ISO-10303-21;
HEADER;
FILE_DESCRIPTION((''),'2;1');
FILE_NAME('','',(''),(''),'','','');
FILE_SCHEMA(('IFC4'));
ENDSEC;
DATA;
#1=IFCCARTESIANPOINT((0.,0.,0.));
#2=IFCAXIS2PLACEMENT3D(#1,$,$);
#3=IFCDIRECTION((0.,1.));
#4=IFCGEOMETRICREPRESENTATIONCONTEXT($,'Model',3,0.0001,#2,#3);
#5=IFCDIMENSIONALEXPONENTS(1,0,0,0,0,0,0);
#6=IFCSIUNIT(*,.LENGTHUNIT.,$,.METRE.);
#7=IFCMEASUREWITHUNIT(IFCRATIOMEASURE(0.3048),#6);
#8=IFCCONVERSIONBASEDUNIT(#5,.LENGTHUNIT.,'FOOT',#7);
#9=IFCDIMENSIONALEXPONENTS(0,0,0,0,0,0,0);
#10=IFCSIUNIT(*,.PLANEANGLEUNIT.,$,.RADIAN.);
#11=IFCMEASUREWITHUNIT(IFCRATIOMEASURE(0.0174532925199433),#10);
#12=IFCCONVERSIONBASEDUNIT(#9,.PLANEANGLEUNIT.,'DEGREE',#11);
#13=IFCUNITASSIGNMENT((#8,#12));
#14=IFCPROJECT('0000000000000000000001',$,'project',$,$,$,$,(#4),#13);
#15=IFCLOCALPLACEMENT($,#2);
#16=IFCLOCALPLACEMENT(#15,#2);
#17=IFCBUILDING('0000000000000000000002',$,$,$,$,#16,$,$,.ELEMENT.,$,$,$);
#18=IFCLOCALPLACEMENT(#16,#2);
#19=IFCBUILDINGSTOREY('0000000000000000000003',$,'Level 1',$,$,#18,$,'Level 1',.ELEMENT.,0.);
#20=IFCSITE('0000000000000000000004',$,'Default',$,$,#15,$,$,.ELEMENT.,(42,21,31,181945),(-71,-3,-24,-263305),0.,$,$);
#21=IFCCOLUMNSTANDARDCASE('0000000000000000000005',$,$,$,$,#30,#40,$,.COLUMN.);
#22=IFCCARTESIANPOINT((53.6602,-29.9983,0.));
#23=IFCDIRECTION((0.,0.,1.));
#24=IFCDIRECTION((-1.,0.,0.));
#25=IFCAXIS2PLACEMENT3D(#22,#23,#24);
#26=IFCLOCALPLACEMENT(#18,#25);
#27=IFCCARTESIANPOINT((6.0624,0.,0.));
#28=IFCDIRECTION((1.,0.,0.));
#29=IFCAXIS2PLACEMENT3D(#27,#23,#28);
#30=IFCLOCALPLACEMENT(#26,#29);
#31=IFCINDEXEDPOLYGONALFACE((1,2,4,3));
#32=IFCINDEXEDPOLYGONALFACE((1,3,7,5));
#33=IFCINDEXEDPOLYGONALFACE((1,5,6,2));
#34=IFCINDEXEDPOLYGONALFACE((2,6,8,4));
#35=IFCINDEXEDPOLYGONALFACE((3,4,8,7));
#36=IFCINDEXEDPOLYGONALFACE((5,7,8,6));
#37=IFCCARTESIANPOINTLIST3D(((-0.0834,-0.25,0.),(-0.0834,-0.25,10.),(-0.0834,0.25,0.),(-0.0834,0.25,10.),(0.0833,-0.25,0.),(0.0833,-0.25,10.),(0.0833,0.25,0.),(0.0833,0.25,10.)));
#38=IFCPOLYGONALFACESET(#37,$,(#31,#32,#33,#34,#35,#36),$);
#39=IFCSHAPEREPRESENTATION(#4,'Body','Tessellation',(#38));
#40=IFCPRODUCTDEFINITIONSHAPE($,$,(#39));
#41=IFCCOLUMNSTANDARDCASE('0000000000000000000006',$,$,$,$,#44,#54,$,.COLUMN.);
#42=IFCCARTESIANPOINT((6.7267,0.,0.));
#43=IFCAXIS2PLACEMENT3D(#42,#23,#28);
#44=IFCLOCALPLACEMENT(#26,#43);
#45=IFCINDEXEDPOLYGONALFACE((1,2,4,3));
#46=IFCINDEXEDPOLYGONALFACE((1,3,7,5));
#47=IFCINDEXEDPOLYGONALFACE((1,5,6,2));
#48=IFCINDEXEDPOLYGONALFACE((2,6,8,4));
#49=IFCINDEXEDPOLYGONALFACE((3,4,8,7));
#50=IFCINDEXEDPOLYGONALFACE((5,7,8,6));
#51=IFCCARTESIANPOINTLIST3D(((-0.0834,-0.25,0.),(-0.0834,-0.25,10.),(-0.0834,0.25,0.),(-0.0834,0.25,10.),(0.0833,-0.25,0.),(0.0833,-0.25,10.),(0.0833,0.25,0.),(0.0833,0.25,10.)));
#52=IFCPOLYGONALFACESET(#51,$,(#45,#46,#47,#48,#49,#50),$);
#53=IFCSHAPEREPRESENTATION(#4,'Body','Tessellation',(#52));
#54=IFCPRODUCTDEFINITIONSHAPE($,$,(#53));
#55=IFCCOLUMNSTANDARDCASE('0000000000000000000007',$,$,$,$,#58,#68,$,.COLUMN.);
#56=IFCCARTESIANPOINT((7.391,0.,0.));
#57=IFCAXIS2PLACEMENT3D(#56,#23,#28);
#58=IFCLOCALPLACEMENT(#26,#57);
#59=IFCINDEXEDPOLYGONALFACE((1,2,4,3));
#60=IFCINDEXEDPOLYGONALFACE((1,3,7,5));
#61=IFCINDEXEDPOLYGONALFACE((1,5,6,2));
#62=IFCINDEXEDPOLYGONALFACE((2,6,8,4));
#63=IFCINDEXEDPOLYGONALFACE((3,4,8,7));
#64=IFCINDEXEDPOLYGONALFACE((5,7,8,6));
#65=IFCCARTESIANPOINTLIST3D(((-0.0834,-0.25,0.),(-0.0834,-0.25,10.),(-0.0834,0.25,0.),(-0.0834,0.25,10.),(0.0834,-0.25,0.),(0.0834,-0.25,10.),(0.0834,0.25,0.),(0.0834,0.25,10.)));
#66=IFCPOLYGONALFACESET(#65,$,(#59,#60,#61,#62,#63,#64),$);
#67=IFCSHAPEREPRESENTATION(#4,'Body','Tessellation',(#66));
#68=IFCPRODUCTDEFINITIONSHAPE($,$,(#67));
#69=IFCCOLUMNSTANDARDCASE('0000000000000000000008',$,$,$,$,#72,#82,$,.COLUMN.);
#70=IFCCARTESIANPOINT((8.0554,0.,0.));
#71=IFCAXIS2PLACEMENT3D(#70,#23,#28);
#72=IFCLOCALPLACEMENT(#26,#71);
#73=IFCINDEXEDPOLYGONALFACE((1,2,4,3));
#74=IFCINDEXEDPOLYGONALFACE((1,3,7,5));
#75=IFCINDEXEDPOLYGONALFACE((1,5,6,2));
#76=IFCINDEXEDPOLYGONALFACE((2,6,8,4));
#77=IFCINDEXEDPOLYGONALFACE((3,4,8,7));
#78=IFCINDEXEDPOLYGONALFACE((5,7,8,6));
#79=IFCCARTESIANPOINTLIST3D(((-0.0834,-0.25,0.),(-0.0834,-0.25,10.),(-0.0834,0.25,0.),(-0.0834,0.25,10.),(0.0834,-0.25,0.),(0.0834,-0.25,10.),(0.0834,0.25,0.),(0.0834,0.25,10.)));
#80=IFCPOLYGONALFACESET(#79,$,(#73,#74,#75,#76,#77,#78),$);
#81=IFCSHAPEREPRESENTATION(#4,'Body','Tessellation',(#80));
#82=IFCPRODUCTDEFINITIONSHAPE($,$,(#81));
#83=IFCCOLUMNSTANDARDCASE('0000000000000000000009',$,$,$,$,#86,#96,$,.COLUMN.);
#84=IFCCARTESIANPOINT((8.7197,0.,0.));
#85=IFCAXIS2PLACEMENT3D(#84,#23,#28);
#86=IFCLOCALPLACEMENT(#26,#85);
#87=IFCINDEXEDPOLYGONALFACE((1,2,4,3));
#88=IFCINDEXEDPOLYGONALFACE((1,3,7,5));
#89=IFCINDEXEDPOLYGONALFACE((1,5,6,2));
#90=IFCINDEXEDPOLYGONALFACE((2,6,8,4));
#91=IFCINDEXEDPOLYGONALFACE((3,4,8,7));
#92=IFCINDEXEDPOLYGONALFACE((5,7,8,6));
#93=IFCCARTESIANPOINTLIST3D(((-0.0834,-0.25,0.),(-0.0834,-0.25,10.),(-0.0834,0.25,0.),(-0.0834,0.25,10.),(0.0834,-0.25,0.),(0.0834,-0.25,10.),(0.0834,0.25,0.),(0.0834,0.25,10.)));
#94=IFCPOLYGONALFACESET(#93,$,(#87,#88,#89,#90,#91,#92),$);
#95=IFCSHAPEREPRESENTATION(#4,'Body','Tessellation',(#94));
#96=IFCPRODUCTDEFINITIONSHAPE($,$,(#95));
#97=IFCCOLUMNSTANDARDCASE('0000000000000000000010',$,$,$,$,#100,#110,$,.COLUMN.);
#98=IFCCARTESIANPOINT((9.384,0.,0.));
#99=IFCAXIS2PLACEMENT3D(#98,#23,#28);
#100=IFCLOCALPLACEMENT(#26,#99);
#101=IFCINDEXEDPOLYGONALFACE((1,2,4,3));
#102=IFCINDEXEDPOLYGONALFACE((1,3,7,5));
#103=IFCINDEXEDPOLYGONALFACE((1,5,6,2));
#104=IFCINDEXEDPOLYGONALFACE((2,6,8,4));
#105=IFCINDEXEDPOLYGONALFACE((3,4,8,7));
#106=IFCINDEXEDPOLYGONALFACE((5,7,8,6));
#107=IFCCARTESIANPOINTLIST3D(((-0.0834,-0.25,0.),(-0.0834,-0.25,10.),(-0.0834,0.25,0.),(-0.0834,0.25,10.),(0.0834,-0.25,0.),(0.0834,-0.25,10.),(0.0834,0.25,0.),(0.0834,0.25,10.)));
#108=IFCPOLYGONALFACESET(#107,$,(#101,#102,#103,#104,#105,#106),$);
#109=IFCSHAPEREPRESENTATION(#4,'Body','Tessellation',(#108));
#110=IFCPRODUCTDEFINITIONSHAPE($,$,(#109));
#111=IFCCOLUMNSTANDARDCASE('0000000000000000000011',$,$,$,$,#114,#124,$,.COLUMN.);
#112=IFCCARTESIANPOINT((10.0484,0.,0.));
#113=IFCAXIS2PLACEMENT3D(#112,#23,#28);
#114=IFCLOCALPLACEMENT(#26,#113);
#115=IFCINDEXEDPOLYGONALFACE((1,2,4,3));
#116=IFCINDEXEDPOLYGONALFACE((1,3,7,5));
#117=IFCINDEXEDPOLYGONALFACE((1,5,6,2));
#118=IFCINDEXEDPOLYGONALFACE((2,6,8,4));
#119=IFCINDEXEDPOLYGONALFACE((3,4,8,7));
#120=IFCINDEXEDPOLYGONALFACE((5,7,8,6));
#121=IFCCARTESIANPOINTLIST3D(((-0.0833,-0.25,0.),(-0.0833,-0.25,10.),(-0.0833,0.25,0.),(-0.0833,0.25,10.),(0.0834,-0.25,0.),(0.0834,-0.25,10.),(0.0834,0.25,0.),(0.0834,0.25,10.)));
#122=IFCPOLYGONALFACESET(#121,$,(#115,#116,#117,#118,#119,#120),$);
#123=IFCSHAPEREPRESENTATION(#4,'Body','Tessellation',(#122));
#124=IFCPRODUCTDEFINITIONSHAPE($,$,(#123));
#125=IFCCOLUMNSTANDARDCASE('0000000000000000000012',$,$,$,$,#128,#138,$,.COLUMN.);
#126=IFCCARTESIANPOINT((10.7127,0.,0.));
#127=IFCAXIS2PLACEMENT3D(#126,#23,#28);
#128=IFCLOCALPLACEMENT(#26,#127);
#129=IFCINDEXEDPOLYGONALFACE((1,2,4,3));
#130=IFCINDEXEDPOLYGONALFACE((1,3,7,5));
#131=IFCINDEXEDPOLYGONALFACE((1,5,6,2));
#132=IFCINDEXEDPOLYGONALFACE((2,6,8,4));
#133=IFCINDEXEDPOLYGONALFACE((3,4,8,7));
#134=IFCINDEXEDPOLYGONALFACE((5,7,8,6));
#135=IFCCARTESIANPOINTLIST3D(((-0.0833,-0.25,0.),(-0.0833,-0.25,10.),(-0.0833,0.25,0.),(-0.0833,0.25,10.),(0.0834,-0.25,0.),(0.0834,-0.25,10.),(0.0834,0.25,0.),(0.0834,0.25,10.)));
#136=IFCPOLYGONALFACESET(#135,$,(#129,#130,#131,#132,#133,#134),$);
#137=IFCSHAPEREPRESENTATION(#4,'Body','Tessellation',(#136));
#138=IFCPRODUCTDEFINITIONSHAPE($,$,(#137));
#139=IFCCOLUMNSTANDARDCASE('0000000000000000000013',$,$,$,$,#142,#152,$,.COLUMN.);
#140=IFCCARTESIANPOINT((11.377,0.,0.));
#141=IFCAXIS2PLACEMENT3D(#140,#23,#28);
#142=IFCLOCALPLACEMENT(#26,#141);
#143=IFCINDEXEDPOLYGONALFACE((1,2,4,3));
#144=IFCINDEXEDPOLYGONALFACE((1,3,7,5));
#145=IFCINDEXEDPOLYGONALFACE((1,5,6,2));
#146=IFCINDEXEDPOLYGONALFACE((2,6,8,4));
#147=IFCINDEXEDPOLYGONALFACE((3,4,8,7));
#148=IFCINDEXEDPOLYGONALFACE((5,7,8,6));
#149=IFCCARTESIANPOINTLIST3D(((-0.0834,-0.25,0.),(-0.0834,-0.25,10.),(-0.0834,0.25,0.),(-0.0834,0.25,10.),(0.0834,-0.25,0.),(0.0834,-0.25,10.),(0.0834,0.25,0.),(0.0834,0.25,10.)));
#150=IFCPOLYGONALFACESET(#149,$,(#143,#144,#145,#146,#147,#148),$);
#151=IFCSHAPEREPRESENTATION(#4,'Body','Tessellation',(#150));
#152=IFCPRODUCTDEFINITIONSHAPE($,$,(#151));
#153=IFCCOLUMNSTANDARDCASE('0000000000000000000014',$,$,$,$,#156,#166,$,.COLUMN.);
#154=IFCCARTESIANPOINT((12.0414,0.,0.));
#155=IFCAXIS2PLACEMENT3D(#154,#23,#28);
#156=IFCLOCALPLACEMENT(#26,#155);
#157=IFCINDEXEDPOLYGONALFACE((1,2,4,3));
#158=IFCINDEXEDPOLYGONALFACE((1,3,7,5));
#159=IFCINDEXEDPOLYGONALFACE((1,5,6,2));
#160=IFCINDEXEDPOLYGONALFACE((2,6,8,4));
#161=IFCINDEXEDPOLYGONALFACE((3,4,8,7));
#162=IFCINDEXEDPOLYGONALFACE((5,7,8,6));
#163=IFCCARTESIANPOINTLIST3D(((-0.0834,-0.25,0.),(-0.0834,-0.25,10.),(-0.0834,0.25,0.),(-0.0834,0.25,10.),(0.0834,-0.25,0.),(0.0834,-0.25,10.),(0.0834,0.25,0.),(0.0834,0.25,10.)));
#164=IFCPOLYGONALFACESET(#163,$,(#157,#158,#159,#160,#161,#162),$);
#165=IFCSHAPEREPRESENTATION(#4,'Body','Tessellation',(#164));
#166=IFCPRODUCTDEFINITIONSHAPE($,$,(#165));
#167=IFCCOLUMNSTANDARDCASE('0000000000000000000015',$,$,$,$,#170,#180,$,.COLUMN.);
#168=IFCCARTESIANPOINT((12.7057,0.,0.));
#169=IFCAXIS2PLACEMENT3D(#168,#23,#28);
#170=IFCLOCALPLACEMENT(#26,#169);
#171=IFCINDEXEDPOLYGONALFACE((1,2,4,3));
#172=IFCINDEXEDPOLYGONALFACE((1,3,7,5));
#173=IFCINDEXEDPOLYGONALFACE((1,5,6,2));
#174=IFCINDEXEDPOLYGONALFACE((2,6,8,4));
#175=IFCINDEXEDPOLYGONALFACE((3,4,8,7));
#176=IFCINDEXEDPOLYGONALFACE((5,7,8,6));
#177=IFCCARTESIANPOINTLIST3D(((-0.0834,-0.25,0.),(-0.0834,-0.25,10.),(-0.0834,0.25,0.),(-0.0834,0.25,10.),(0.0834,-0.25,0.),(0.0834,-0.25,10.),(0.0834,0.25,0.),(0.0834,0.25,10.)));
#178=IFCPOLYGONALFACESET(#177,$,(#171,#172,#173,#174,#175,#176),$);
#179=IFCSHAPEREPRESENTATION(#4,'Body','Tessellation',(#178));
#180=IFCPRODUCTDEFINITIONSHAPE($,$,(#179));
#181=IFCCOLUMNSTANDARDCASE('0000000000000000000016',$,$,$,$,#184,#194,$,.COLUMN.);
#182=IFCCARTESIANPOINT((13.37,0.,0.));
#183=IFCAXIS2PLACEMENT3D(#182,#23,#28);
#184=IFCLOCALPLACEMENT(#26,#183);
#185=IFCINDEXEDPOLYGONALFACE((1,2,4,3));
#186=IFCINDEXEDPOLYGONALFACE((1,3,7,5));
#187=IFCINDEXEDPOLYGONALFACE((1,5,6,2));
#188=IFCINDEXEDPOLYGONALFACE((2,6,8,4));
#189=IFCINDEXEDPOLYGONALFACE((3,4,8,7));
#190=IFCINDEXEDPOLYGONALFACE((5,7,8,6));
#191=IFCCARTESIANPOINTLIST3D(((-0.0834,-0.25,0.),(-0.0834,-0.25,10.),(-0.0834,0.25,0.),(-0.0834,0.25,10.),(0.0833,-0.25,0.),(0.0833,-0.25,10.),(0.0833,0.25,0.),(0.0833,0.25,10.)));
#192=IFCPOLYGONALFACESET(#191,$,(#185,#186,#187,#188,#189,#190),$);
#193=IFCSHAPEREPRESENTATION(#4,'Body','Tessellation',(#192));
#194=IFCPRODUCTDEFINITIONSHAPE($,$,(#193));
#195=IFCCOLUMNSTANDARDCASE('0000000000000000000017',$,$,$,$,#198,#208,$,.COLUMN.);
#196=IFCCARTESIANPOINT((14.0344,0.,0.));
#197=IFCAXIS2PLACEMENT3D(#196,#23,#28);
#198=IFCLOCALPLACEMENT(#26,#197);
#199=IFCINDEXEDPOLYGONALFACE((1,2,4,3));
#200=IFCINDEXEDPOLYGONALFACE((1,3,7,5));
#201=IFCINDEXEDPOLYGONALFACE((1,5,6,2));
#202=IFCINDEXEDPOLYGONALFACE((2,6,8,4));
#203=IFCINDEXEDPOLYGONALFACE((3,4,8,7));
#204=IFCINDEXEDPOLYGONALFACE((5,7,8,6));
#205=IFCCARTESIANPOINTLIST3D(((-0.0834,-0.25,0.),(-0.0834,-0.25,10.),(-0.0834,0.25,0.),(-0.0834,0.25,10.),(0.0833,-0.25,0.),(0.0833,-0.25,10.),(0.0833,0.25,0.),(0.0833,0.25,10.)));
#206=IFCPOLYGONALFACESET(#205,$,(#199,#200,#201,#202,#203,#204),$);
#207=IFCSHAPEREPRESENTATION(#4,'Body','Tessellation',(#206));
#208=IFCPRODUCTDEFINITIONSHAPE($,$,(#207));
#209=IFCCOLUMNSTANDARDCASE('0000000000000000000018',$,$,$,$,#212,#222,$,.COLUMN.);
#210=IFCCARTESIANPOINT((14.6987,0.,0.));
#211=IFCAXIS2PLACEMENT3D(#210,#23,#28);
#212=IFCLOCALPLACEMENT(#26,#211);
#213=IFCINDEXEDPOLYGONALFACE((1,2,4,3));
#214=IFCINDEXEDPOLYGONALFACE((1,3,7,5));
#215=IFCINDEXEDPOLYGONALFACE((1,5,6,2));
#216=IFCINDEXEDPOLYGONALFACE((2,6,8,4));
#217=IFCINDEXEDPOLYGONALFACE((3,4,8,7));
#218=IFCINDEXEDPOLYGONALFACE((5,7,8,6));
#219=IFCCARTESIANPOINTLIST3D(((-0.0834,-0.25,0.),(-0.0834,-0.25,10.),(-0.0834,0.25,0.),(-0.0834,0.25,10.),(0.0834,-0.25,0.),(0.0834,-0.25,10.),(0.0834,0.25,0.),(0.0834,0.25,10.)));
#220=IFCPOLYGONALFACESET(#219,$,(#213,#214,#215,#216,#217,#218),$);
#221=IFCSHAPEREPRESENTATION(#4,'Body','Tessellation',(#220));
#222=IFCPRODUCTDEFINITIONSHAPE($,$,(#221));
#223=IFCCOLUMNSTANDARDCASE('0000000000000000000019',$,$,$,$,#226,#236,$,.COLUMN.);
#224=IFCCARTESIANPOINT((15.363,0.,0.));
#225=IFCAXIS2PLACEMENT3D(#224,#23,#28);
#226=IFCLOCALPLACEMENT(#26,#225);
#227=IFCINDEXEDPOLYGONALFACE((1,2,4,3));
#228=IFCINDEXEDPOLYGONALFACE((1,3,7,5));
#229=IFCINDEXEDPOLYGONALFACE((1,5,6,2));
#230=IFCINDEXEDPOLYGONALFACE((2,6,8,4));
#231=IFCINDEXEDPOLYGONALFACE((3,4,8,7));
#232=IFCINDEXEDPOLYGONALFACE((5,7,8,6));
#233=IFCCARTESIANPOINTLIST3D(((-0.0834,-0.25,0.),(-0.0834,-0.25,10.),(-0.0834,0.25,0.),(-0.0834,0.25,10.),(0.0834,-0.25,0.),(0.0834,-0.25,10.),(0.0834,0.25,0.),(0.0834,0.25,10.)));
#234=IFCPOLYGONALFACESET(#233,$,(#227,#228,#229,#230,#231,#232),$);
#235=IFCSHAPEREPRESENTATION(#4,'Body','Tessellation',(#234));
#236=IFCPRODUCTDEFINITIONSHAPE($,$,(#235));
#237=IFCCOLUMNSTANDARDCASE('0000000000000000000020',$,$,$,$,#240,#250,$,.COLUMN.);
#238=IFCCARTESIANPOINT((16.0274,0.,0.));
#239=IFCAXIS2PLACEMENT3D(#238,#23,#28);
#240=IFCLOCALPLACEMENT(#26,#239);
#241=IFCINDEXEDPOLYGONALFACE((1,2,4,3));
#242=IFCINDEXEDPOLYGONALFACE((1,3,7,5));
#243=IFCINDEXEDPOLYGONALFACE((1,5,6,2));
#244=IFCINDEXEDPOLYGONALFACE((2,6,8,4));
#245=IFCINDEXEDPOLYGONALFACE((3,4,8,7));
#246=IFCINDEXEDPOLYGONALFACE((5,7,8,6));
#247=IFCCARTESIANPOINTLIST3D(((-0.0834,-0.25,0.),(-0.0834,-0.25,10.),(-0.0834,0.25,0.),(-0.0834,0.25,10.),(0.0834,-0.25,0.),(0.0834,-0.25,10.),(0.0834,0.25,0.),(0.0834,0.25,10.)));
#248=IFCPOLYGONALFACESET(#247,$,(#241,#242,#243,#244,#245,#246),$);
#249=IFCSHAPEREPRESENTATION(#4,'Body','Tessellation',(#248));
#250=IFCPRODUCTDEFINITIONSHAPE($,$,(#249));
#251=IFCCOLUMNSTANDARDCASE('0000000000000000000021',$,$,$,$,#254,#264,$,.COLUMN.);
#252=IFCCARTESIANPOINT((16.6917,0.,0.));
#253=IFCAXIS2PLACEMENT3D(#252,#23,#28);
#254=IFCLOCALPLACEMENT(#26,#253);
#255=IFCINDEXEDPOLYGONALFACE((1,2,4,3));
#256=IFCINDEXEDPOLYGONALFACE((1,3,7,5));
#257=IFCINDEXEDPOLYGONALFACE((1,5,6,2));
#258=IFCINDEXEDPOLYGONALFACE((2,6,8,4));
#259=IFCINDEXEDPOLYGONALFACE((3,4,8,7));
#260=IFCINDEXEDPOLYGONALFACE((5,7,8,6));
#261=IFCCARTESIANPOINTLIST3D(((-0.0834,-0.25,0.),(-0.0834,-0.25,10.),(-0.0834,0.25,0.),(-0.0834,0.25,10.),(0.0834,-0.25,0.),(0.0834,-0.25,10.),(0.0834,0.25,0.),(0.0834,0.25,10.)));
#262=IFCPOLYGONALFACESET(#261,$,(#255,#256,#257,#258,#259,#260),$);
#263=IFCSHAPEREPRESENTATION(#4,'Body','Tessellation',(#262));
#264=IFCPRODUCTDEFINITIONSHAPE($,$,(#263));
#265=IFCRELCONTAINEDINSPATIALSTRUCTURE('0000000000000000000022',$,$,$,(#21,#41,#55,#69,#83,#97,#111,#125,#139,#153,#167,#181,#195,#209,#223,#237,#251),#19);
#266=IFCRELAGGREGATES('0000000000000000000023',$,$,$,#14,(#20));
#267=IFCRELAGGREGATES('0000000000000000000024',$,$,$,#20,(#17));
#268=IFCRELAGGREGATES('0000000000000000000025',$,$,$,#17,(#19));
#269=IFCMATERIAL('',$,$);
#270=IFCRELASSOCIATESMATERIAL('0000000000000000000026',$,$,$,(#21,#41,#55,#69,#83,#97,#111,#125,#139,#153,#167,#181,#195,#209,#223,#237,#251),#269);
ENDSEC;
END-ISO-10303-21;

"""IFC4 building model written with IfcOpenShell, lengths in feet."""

from ifc_helpers import new_model, entity, si_unit, converted_unit, direction, frame, origin, place, context, project, spatial, rectangle, extrude, material, element, save


model = new_model("IFC4")

# Units and contexts
model_context = context("Model", 3, precision=0.0001, world=origin(), true_north=direction((0.0, 1.0)))
ifc_project = project(units=[converted_unit("LENGTHUNIT", "FOOT", entity("IfcRatioMeasure", 0.3048), si_unit("LENGTHUNIT", "METRE"), dimensions=[1, 0, 0, 0, 0, 0, 0]), converted_unit("PLANEANGLEUNIT", "DEGREE", entity("IfcRatioMeasure", 0.0174532925199433), si_unit("PLANEANGLEUNIT", "RADIAN"), dimensions=[0, 0, 0, 0, 0, 0, 0])], contexts=[model_context])

# Site, building, storey
site_placement = place(None, origin())
site = spatial("IfcSite", under=ifc_project, at=site_placement, Name="Default", CompositionType="ELEMENT", RefLatitude=(42, 21, 31, 181945), RefLongitude=(-71, -3, -24, -263305), RefElevation=0.0)
building_placement = place(site_placement, origin())
building = spatial("IfcBuilding", under=site, at=building_placement, CompositionType="ELEMENT")
storey_placement = place(building_placement, origin())
storey = spatial("IfcBuildingStorey", under=building, at=storey_placement, Name="Level 1", LongName="Level 1", CompositionType="ELEMENT", Elevation=0.0)

# Columns
ifc_material = material(Name="")
placement_1 = place(storey_placement, frame((53.6602, -29.9983, 0.0), z_axis=(0.0, 0.0, 1.0), x_axis=(-1.0, 0.0, 0.0)))
for number, where, z_axis, x_axis in (
    (1, (6.0624, 0.0, 0.0), (0.0, 0.0, 1.0), (1.0, 0.0, 0.0)),
    (2, (6.7267, 0.0, 0.0), (0.0, 0.0, 1.0), (1.0, 0.0, 0.0)),
    (3, (7.391, 0.0, 0.0), (0.0, 0.0, 1.0), (1.0, 0.0, 0.0)),
    (4, (8.0554, 0.0, 0.0), (0.0, 0.0, 1.0), (1.0, 0.0, 0.0)),
    (5, (8.7197, 0.0, 0.0), (0.0, 0.0, 1.0), (1.0, 0.0, 0.0)),
    (6, (9.384, 0.0, 0.0), (0.0, 0.0, 1.0), (1.0, 0.0, 0.0)),
    (7, (10.0484, 0.0, 0.0), (0.0, 0.0, 1.0), (1.0, 0.0, 0.0)),
    (8, (10.7127, 0.0, 0.0), (0.0, 0.0, 1.0), (1.0, 0.0, 0.0)),
    (9, (11.377, 0.0, 0.0), (0.0, 0.0, 1.0), (1.0, 0.0, 0.0)),
    (10, (12.0414, 0.0, 0.0), (0.0, 0.0, 1.0), (1.0, 0.0, 0.0)),
    (11, (12.7057, 0.0, 0.0), (0.0, 0.0, 1.0), (1.0, 0.0, 0.0)),
    (12, (13.37, 0.0, 0.0), (0.0, 0.0, 1.0), (1.0, 0.0, 0.0)),
    (13, (14.0344, 0.0, 0.0), (0.0, 0.0, 1.0), (1.0, 0.0, 0.0)),
    (14, (14.6987, 0.0, 0.0), (0.0, 0.0, 1.0), (1.0, 0.0, 0.0)),
    (15, (15.363, 0.0, 0.0), (0.0, 0.0, 1.0), (1.0, 0.0, 0.0)),
    (16, (16.0274, 0.0, 0.0), (0.0, 0.0, 1.0), (1.0, 0.0, 0.0)),
    (17, (16.6917, 0.0, 0.0), (0.0, 0.0, 1.0), (1.0, 0.0, 0.0)),
):
    element("IfcColumnStandardCase", number, at=place(placement_1, frame(where, z_axis=z_axis, x_axis=x_axis)), inside=storey, material=ifc_material, PredefinedType="COLUMN", context=model_context, shape_type="SweptSolid", body=[
        extrude(rectangle(XDim=0.1667, YDim=0.5), origin(), (0.0, 0.0, 1.0), 10.0),
    ])

save(model, "model.ifc")
